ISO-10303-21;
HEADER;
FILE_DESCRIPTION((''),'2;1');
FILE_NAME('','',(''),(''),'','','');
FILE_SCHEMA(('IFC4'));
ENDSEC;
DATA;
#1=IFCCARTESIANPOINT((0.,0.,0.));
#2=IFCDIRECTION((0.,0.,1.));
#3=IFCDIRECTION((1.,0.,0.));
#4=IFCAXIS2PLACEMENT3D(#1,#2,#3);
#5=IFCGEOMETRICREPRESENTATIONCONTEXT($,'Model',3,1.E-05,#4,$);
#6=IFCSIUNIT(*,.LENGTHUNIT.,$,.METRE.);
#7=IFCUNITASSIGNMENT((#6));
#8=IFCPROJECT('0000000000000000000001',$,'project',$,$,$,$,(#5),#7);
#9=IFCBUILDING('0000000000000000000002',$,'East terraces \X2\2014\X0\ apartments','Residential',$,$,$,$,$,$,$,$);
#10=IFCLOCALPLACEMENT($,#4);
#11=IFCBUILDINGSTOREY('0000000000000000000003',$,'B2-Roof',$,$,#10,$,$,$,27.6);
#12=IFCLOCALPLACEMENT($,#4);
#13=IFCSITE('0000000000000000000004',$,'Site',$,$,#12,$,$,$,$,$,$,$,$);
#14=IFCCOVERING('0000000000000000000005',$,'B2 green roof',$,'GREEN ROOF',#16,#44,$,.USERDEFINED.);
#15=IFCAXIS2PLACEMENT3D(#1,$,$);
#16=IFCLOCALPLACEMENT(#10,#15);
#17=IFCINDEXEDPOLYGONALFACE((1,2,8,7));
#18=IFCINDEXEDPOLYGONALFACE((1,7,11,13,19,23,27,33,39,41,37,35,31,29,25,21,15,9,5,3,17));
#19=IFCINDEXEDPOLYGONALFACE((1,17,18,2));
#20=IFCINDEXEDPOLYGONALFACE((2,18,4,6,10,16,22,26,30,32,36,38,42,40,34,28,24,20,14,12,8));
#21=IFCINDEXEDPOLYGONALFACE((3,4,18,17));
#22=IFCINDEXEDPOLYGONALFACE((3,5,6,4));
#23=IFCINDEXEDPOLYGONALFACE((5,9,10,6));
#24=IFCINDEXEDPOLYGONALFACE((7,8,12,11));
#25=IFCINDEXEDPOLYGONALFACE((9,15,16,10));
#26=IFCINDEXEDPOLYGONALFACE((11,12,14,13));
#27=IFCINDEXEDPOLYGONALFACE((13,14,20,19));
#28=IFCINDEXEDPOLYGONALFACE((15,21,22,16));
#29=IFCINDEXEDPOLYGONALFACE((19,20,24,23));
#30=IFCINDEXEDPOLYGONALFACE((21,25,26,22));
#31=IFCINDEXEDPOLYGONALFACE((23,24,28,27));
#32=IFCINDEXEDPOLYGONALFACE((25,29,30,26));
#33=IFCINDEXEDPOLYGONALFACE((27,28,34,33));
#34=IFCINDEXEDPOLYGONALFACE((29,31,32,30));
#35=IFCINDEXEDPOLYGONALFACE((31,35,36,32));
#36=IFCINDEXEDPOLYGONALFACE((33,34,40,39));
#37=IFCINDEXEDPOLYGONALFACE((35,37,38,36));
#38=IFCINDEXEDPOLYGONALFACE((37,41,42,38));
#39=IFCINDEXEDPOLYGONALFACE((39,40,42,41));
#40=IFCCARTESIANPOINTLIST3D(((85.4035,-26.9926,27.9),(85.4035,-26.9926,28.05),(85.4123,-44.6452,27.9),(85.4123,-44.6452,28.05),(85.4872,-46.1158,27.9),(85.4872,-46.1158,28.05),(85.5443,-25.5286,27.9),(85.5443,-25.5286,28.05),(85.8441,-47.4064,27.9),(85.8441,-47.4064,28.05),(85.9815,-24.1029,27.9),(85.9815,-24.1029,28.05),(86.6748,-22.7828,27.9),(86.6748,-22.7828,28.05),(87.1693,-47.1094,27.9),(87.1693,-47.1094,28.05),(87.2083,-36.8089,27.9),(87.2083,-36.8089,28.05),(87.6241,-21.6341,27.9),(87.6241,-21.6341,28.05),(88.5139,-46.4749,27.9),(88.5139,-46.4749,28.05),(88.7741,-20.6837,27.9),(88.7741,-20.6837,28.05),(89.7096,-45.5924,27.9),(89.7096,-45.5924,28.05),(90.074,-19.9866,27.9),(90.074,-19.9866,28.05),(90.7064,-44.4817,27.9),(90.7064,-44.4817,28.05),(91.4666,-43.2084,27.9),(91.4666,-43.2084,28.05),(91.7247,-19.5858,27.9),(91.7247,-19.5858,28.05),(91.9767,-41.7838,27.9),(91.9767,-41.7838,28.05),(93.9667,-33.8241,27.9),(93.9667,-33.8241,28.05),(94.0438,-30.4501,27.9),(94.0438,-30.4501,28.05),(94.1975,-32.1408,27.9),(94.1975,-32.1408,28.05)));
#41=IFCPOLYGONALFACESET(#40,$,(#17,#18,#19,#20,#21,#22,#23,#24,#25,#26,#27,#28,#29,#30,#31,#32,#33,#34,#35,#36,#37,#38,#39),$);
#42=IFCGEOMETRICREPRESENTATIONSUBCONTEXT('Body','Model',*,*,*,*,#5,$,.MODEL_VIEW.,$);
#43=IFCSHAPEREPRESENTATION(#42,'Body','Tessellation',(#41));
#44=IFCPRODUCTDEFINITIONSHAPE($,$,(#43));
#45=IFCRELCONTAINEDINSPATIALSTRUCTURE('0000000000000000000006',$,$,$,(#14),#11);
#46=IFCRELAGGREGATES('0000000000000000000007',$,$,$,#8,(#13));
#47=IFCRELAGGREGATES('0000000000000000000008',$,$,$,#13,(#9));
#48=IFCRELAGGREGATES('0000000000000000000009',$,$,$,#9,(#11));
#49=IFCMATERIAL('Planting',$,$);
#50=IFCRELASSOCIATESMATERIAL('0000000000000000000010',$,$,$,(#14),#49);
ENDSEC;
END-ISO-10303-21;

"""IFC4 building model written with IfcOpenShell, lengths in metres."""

from ifc_helpers import new_model, si_unit, frame, origin_with_axes, place, context, subcontext, project, spatial, polyline, outline, extrude, material, element, save


model = new_model("IFC4")

# Units and contexts
model_context = context("Model", 3, precision=1e-05, world=origin_with_axes())
body_context = subcontext(model_context, "Body", "Model", "MODEL_VIEW")
ifc_project = project(units=[si_unit("LENGTHUNIT", "METRE")], contexts=[model_context])

# Site, building, storey
site_placement = place(None, origin_with_axes())
site = spatial("IfcSite", under=ifc_project, at=site_placement, Name="Site")
building = spatial("IfcBuilding", under=site, Name="East terraces — apartments", Description="Residential")
storey_placement = place(None, origin_with_axes())
storey = spatial("IfcBuildingStorey", under=building, at=storey_placement, Name="B2-Roof", Elevation=27.6)

# Covering
ifc_material_1 = material(Name="Planting")
covering_placement = place(storey_placement, origin_with_axes())
element("IfcCovering", 1, at=covering_placement, inside=storey, material=ifc_material_1, Name="B2 green roof", ObjectType="GREEN ROOF", PredefinedType="USERDEFINED", context=body_context, shape_type="SweptSolid", body=[
    extrude(outline(polyline([(85.4035, -26.9926), (87.2083, -36.8089), (85.4123, -44.6452), (85.4872, -46.1158), (85.8441, -47.4064), (87.1693, -47.1094), (88.5139, -46.4749), (89.7096, -45.5924), (90.7064, -44.4817), (91.4666, -43.2084), (91.9767, -41.7838), (93.9667, -33.8241), (94.1975, -32.1408), (94.0438, -30.4501), (91.7247, -19.5858), (90.074, -19.9866), (88.7741, -20.6837), (87.6241, -21.6341), (86.6748, -22.7828), (85.9815, -24.1029), (85.5443, -25.5286), (85.4035, -26.9926)])), frame((0.0, 0.0, 27.9), z_axis=(0.0, 0.0, 1.0), x_axis=(1.0, 0.0, 0.0)), (0.0, 0.0, 1.0), 0.15),
])

save(model, "model.ifc")
